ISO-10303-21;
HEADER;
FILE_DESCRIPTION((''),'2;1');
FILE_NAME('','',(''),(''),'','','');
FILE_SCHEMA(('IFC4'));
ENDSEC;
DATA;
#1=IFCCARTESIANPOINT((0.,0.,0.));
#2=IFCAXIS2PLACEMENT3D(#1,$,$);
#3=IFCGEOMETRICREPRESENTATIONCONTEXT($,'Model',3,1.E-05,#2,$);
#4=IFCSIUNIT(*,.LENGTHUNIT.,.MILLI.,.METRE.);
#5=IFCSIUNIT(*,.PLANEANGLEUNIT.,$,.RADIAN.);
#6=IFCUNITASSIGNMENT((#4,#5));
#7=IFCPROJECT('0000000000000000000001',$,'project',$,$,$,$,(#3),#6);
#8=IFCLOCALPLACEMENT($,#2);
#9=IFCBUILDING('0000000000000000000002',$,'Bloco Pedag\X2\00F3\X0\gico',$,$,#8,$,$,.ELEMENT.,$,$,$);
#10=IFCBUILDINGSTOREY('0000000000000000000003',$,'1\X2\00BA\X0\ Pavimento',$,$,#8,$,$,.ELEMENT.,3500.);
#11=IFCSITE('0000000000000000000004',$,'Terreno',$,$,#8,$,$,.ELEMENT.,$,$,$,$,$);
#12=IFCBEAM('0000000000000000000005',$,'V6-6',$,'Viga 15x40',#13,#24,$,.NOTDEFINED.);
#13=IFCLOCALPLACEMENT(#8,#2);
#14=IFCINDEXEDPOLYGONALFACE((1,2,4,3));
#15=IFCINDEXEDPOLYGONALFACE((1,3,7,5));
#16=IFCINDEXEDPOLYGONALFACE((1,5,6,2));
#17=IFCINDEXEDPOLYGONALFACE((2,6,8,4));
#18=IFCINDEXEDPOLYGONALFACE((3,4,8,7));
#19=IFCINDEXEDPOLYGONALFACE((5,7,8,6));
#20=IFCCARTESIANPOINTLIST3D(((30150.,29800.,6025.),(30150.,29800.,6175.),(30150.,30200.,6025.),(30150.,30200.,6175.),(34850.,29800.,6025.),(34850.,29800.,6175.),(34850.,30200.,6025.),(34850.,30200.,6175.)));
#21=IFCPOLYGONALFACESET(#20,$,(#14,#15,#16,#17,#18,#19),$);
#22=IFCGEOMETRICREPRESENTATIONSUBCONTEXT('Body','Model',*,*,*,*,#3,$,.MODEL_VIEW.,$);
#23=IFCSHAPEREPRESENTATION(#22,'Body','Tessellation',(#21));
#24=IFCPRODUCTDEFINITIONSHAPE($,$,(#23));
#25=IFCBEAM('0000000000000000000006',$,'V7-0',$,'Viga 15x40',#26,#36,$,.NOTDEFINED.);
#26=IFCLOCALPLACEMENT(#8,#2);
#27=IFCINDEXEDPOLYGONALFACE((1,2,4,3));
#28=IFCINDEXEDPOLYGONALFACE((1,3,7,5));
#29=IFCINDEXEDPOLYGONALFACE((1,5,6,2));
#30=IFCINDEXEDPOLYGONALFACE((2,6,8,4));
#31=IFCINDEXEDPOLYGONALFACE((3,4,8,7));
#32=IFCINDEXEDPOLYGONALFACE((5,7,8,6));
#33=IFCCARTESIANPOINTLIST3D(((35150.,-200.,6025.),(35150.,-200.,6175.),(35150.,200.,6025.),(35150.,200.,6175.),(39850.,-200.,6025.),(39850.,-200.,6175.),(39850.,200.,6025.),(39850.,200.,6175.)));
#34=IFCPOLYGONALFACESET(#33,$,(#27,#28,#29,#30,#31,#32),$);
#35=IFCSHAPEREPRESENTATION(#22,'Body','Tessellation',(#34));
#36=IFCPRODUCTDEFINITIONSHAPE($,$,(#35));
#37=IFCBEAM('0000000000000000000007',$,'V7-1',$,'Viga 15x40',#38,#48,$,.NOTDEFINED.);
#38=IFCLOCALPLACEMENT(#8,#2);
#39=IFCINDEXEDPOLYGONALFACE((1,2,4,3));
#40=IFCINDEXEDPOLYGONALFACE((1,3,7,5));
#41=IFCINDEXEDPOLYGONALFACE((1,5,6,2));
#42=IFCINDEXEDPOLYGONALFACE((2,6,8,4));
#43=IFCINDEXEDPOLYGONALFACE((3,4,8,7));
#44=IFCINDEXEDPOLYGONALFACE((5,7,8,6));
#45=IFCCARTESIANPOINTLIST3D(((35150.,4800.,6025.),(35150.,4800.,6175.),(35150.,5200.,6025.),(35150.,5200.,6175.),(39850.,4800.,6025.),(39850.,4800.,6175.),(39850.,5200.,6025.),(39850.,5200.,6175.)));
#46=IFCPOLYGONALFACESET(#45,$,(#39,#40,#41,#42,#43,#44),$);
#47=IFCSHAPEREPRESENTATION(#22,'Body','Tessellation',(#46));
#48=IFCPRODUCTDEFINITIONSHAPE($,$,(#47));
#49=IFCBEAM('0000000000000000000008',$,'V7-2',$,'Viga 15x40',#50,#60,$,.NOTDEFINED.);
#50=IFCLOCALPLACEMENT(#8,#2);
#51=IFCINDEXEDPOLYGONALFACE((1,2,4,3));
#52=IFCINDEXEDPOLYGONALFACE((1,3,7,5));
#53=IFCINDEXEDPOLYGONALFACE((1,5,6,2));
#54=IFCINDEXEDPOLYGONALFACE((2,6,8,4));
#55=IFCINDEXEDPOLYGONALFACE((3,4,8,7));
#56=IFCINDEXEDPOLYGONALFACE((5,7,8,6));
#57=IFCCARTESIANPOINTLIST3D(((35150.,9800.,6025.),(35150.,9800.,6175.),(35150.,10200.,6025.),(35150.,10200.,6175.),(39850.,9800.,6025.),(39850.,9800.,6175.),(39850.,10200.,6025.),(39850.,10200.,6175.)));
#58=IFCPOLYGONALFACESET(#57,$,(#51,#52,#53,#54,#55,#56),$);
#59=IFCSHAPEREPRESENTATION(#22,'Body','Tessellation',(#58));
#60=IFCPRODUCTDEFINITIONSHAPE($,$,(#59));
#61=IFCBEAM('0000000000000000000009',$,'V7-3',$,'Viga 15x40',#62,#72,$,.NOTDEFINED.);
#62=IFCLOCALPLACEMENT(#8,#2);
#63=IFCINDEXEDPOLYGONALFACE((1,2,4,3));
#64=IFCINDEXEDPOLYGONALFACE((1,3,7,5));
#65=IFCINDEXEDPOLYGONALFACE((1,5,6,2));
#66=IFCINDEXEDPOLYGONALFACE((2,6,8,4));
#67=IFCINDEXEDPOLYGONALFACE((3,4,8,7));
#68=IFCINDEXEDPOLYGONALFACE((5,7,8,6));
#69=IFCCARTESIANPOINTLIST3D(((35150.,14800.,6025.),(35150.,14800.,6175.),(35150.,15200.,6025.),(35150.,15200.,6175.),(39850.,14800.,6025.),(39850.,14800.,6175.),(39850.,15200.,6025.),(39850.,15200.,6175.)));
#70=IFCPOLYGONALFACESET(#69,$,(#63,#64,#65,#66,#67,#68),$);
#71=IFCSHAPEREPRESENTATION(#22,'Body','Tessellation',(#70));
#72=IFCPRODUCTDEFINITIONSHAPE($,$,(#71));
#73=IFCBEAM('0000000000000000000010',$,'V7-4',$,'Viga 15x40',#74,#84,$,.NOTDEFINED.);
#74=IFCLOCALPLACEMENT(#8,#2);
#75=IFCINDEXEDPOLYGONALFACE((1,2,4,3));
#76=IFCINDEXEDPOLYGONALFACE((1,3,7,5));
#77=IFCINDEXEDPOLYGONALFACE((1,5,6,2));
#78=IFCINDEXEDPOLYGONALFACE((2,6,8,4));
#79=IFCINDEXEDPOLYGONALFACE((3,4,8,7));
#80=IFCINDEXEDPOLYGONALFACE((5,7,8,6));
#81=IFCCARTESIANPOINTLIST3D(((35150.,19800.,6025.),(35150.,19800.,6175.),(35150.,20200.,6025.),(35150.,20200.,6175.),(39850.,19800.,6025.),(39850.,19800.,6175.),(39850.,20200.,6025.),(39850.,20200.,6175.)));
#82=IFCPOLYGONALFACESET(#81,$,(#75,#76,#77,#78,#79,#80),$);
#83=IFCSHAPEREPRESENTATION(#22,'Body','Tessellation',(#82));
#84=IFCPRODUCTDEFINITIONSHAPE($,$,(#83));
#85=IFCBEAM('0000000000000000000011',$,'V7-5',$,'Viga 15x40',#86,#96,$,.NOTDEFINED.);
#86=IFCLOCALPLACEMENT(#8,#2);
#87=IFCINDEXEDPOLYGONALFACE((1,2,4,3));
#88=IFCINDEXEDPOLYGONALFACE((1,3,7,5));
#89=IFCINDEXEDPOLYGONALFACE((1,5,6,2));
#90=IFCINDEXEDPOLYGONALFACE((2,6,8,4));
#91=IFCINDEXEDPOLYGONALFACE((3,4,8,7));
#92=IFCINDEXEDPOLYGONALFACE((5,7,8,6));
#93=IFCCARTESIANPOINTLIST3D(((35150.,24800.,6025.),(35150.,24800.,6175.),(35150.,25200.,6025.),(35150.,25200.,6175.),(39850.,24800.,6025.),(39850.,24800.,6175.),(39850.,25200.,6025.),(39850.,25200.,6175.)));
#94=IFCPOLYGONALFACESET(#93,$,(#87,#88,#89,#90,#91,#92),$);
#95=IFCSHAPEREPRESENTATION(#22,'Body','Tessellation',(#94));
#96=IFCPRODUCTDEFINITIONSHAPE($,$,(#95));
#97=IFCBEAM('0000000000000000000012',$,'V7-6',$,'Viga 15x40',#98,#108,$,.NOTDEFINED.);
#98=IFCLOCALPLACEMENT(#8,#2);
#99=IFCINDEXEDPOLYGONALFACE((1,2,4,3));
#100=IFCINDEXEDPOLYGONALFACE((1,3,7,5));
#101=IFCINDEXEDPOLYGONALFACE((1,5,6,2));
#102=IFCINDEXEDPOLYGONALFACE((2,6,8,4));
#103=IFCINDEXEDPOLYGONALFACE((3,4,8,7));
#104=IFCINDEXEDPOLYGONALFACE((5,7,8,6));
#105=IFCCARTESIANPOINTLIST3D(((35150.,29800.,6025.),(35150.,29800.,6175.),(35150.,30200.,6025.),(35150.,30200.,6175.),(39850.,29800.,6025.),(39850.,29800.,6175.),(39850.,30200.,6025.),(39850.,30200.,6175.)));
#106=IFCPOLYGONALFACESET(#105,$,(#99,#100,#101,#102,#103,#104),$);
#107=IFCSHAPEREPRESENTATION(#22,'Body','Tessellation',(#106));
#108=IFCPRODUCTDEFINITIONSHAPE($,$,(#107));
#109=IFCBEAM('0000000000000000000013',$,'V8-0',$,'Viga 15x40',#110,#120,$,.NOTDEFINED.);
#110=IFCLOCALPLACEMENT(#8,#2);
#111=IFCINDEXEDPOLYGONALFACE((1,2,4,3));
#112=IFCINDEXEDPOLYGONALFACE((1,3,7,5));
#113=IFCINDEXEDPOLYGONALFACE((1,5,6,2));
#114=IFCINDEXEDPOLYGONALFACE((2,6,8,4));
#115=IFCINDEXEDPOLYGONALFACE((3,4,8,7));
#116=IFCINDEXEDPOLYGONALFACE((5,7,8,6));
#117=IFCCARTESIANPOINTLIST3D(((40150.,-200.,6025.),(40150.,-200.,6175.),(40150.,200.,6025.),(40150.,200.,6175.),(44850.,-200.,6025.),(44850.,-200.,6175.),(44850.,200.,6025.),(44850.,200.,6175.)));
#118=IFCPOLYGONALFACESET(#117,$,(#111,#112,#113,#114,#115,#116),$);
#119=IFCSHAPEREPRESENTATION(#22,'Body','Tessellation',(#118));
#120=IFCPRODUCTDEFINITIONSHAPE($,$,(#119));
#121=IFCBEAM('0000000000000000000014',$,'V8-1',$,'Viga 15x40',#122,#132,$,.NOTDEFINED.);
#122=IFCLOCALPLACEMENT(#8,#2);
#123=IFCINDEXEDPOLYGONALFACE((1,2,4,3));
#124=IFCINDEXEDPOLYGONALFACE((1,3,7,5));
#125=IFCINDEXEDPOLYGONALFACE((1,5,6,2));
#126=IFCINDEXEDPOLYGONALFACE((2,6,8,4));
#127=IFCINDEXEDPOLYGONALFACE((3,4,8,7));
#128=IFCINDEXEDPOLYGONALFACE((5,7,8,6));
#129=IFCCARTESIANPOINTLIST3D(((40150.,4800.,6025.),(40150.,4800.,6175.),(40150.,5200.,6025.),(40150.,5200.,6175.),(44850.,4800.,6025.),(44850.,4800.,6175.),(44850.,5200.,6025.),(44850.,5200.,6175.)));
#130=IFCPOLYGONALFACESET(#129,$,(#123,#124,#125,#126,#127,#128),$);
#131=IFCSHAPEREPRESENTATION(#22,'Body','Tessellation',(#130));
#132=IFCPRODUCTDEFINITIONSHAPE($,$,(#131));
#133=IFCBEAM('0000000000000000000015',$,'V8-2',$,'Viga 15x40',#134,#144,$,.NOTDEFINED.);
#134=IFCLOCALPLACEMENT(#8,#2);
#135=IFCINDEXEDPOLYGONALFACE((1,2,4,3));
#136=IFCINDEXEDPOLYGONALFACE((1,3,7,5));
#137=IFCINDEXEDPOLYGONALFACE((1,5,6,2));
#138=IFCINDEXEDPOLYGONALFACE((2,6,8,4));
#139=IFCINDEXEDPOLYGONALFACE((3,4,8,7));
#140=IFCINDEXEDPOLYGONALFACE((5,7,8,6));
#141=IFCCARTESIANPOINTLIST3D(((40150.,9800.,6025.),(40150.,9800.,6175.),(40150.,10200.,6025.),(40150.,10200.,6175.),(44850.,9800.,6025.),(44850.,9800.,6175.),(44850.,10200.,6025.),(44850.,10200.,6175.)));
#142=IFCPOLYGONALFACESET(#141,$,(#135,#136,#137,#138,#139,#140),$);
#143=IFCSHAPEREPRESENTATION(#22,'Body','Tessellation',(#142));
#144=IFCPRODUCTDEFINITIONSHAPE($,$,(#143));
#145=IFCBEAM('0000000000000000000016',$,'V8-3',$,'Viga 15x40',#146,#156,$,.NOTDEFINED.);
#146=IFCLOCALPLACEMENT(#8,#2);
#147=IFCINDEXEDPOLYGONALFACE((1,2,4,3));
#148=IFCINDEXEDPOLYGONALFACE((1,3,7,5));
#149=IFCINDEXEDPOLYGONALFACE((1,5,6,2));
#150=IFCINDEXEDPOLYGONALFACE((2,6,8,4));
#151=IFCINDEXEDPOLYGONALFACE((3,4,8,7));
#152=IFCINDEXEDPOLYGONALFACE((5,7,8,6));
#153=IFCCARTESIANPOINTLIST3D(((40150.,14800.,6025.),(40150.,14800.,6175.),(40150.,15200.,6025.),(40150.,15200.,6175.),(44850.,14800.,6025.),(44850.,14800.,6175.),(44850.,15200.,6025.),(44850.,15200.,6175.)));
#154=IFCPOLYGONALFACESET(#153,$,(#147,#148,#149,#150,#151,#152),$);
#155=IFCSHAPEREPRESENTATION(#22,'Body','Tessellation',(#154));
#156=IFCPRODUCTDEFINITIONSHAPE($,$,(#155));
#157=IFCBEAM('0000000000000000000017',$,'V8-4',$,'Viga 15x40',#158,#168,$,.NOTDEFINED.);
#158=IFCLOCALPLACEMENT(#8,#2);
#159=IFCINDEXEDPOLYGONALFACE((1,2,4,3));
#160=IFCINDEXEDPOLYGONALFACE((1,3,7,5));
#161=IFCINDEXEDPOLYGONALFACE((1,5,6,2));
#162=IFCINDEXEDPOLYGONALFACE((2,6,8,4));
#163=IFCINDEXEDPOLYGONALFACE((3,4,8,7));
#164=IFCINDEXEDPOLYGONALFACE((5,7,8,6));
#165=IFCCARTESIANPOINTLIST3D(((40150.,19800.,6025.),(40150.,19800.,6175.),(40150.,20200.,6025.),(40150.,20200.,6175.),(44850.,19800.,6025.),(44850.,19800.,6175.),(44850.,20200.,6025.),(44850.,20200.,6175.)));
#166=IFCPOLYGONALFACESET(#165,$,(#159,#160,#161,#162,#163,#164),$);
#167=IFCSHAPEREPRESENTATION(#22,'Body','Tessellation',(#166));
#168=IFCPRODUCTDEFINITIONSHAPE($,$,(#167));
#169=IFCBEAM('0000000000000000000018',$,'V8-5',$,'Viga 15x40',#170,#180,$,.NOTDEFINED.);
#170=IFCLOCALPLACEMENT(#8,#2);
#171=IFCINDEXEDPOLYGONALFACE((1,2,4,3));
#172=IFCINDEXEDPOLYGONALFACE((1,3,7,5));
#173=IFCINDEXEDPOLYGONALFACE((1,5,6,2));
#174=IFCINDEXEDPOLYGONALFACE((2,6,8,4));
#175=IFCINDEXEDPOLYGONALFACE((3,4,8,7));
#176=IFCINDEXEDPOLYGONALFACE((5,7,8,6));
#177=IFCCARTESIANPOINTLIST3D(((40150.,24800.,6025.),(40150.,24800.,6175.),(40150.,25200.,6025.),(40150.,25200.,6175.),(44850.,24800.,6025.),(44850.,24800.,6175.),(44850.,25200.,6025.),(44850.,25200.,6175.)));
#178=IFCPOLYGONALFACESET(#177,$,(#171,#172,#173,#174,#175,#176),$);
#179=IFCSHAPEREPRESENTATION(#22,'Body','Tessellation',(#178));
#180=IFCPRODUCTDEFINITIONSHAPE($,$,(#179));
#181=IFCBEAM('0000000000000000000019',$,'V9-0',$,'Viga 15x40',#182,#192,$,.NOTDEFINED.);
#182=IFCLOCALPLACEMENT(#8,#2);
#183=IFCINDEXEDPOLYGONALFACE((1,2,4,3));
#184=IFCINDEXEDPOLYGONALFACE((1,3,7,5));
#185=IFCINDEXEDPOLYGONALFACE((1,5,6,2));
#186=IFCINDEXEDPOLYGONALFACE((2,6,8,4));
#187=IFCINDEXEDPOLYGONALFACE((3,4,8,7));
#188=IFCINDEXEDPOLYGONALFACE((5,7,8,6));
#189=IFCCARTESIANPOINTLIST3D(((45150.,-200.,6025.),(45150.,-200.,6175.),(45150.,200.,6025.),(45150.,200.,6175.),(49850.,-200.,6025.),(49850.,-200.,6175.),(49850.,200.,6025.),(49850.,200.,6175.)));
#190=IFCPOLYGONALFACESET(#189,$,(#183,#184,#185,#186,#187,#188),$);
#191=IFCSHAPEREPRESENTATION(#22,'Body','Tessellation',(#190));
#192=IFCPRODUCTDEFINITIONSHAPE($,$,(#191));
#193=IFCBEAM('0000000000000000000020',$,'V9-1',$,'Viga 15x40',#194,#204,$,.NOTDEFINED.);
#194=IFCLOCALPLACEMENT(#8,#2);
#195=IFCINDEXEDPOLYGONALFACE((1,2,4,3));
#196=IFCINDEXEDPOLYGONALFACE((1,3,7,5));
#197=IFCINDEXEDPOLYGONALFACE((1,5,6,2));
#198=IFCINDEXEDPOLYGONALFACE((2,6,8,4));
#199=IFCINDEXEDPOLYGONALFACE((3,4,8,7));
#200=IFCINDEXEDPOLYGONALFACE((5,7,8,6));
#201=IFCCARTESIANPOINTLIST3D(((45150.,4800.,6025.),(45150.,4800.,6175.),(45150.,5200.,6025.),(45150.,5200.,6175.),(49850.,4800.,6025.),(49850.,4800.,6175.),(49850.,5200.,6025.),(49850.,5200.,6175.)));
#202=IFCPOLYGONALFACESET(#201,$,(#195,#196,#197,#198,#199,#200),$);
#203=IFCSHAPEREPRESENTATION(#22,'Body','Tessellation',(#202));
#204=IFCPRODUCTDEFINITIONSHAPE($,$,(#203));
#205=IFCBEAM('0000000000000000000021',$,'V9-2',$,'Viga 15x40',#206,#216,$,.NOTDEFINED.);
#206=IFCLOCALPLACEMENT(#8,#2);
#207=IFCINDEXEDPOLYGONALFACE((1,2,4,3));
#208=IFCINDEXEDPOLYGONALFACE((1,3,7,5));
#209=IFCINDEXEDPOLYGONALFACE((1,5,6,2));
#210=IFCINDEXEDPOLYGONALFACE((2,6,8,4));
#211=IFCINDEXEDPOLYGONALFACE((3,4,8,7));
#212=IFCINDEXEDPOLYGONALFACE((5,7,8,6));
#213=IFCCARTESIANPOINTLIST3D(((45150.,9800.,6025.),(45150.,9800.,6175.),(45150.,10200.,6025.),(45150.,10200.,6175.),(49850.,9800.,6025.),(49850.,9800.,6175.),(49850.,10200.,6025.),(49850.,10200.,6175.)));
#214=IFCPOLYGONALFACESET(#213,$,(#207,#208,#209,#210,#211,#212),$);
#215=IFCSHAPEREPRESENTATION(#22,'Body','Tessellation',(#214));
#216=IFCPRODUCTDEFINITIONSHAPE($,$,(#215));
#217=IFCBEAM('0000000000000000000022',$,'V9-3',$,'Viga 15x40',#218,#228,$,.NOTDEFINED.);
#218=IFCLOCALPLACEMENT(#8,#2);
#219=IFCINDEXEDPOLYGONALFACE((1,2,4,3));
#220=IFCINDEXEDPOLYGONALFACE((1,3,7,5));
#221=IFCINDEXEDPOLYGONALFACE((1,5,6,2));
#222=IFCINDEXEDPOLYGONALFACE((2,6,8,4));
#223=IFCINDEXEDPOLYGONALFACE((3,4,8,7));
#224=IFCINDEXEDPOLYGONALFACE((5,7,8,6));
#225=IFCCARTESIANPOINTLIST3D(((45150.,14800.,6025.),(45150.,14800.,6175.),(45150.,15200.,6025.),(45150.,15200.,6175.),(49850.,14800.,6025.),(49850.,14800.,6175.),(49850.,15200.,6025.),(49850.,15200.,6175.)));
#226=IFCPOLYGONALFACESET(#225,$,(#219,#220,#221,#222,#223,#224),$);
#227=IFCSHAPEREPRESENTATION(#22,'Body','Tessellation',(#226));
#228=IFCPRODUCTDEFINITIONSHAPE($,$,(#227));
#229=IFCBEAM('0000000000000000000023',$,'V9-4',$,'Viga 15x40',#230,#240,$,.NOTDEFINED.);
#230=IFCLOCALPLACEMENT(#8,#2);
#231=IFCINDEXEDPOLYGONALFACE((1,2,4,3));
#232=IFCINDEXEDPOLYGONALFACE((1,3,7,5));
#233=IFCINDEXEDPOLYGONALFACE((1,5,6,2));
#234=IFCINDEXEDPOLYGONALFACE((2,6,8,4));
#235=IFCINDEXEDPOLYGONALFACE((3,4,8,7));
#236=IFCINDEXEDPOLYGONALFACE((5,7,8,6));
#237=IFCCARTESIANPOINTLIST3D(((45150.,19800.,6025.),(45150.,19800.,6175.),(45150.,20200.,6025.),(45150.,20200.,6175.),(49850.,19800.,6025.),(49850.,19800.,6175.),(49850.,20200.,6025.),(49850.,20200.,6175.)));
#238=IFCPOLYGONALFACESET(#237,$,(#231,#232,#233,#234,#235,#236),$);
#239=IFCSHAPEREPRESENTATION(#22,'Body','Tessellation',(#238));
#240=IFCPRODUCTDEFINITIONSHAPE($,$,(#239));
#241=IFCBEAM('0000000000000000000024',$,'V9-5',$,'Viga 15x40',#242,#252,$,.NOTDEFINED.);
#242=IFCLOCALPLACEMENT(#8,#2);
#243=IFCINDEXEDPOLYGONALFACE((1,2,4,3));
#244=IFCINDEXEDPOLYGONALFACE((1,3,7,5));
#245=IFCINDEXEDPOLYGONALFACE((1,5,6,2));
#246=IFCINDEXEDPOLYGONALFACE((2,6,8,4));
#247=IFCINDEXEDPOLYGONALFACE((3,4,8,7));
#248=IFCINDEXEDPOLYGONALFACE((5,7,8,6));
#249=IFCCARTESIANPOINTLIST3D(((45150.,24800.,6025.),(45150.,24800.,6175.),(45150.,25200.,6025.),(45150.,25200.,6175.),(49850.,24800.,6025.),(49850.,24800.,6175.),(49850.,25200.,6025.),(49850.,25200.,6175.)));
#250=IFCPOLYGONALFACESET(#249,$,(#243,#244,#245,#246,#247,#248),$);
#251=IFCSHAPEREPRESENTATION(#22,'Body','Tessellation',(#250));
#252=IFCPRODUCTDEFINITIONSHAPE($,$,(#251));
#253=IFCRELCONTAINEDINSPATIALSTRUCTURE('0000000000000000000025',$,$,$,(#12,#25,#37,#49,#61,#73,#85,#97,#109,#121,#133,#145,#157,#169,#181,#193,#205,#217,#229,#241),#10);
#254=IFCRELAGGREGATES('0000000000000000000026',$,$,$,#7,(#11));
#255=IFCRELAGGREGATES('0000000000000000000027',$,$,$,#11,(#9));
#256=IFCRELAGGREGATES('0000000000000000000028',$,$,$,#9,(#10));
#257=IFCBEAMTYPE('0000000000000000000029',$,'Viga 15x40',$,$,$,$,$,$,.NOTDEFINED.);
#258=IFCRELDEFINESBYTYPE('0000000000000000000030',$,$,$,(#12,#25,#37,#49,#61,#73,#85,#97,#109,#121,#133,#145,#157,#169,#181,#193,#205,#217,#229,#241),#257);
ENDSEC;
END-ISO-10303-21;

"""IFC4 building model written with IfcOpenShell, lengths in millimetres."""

from ifc_helpers import new_model, si_unit, frame, origin, origin_2d, place, context, subcontext, project, spatial, rectangle, extrude, type_object, element, save


model = new_model("IFC4")

# Units and contexts
model_context = context("Model", 3, precision=1e-05, world=origin())
body_context = subcontext(model_context, "Body", "Model", "MODEL_VIEW")
ifc_project = project(units=[si_unit("LENGTHUNIT", "METRE", prefix="MILLI"), si_unit("PLANEANGLEUNIT", "RADIAN")], contexts=[model_context])

# Site, building, storey
placement = place(None, origin())
site = spatial("IfcSite", under=ifc_project, at=placement, Name="Terreno", CompositionType="ELEMENT")
building = spatial("IfcBuilding", under=site, at=placement, Name="Bloco Pedagógico", CompositionType="ELEMENT")
storey = spatial("IfcBuildingStorey", under=building, at=placement, Name="1º Pavimento", CompositionType="ELEMENT", Elevation=3500.0)

# Beams
beam_type = type_object("IfcBeamType", Name="Viga 15x40", PredefinedType="NOTDEFINED")
for number, where, z_axis, x_axis, name in (
    (1, (30150.0, 30000.0, 6100.0), (1.0, 0.0, 0.0), (0.0, 1.0, 0.0), "V6-6"),
    (2, (35150.0, 0.0, 6100.0), (1.0, 0.0, 0.0), (0.0, 1.0, 0.0), "V7-0"),
    (3, (35150.0, 5000.0, 6100.0), (1.0, 0.0, 0.0), (0.0, 1.0, 0.0), "V7-1"),
    (4, (35150.0, 10000.0, 6100.0), (1.0, 0.0, 0.0), (0.0, 1.0, 0.0), "V7-2"),
    (5, (35150.0, 15000.0, 6100.0), (1.0, 0.0, 0.0), (0.0, 1.0, 0.0), "V7-3"),
    (6, (35150.0, 20000.0, 6100.0), (1.0, 0.0, 0.0), (0.0, 1.0, 0.0), "V7-4"),
    (7, (35150.0, 25000.0, 6100.0), (1.0, 0.0, 0.0), (0.0, 1.0, 0.0), "V7-5"),
    (8, (35150.0, 30000.0, 6100.0), (1.0, 0.0, 0.0), (0.0, 1.0, 0.0), "V7-6"),
    (9, (40150.0, 0.0, 6100.0), (1.0, 0.0, 0.0), (0.0, 1.0, 0.0), "V8-0"),
    (10, (40150.0, 5000.0, 6100.0), (1.0, 0.0, 0.0), (0.0, 1.0, 0.0), "V8-1"),
    (11, (40150.0, 10000.0, 6100.0), (1.0, 0.0, 0.0), (0.0, 1.0, 0.0), "V8-2"),
    (12, (40150.0, 15000.0, 6100.0), (1.0, 0.0, 0.0), (0.0, 1.0, 0.0), "V8-3"),
    (13, (40150.0, 20000.0, 6100.0), (1.0, 0.0, 0.0), (0.0, 1.0, 0.0), "V8-4"),
    (14, (40150.0, 25000.0, 6100.0), (1.0, 0.0, 0.0), (0.0, 1.0, 0.0), "V8-5"),
    (15, (45150.0, 0.0, 6100.0), (1.0, 0.0, 0.0), (0.0, 1.0, 0.0), "V9-0"),
    (16, (45150.0, 5000.0, 6100.0), (1.0, 0.0, 0.0), (0.0, 1.0, 0.0), "V9-1"),
    (17, (45150.0, 10000.0, 6100.0), (1.0, 0.0, 0.0), (0.0, 1.0, 0.0), "V9-2"),
    (18, (45150.0, 15000.0, 6100.0), (1.0, 0.0, 0.0), (0.0, 1.0, 0.0), "V9-3"),
    (19, (45150.0, 20000.0, 6100.0), (1.0, 0.0, 0.0), (0.0, 1.0, 0.0), "V9-4"),
    (20, (45150.0, 25000.0, 6100.0), (1.0, 0.0, 0.0), (0.0, 1.0, 0.0), "V9-5"),
):
    element("IfcBeam", number, at=place(None, frame(where, z_axis=z_axis, x_axis=x_axis)), inside=storey, type_object=beam_type, Name=name, ObjectType="Viga 15x40", PredefinedType="NOTDEFINED", context=body_context, shape_type="SweptSolid", body=[
        extrude(rectangle(XDim=400.0, YDim=150.0, at=origin_2d()), None, (0.0, 0.0, 1.0), 4700.0),
    ])

save(model, "model.ifc")
